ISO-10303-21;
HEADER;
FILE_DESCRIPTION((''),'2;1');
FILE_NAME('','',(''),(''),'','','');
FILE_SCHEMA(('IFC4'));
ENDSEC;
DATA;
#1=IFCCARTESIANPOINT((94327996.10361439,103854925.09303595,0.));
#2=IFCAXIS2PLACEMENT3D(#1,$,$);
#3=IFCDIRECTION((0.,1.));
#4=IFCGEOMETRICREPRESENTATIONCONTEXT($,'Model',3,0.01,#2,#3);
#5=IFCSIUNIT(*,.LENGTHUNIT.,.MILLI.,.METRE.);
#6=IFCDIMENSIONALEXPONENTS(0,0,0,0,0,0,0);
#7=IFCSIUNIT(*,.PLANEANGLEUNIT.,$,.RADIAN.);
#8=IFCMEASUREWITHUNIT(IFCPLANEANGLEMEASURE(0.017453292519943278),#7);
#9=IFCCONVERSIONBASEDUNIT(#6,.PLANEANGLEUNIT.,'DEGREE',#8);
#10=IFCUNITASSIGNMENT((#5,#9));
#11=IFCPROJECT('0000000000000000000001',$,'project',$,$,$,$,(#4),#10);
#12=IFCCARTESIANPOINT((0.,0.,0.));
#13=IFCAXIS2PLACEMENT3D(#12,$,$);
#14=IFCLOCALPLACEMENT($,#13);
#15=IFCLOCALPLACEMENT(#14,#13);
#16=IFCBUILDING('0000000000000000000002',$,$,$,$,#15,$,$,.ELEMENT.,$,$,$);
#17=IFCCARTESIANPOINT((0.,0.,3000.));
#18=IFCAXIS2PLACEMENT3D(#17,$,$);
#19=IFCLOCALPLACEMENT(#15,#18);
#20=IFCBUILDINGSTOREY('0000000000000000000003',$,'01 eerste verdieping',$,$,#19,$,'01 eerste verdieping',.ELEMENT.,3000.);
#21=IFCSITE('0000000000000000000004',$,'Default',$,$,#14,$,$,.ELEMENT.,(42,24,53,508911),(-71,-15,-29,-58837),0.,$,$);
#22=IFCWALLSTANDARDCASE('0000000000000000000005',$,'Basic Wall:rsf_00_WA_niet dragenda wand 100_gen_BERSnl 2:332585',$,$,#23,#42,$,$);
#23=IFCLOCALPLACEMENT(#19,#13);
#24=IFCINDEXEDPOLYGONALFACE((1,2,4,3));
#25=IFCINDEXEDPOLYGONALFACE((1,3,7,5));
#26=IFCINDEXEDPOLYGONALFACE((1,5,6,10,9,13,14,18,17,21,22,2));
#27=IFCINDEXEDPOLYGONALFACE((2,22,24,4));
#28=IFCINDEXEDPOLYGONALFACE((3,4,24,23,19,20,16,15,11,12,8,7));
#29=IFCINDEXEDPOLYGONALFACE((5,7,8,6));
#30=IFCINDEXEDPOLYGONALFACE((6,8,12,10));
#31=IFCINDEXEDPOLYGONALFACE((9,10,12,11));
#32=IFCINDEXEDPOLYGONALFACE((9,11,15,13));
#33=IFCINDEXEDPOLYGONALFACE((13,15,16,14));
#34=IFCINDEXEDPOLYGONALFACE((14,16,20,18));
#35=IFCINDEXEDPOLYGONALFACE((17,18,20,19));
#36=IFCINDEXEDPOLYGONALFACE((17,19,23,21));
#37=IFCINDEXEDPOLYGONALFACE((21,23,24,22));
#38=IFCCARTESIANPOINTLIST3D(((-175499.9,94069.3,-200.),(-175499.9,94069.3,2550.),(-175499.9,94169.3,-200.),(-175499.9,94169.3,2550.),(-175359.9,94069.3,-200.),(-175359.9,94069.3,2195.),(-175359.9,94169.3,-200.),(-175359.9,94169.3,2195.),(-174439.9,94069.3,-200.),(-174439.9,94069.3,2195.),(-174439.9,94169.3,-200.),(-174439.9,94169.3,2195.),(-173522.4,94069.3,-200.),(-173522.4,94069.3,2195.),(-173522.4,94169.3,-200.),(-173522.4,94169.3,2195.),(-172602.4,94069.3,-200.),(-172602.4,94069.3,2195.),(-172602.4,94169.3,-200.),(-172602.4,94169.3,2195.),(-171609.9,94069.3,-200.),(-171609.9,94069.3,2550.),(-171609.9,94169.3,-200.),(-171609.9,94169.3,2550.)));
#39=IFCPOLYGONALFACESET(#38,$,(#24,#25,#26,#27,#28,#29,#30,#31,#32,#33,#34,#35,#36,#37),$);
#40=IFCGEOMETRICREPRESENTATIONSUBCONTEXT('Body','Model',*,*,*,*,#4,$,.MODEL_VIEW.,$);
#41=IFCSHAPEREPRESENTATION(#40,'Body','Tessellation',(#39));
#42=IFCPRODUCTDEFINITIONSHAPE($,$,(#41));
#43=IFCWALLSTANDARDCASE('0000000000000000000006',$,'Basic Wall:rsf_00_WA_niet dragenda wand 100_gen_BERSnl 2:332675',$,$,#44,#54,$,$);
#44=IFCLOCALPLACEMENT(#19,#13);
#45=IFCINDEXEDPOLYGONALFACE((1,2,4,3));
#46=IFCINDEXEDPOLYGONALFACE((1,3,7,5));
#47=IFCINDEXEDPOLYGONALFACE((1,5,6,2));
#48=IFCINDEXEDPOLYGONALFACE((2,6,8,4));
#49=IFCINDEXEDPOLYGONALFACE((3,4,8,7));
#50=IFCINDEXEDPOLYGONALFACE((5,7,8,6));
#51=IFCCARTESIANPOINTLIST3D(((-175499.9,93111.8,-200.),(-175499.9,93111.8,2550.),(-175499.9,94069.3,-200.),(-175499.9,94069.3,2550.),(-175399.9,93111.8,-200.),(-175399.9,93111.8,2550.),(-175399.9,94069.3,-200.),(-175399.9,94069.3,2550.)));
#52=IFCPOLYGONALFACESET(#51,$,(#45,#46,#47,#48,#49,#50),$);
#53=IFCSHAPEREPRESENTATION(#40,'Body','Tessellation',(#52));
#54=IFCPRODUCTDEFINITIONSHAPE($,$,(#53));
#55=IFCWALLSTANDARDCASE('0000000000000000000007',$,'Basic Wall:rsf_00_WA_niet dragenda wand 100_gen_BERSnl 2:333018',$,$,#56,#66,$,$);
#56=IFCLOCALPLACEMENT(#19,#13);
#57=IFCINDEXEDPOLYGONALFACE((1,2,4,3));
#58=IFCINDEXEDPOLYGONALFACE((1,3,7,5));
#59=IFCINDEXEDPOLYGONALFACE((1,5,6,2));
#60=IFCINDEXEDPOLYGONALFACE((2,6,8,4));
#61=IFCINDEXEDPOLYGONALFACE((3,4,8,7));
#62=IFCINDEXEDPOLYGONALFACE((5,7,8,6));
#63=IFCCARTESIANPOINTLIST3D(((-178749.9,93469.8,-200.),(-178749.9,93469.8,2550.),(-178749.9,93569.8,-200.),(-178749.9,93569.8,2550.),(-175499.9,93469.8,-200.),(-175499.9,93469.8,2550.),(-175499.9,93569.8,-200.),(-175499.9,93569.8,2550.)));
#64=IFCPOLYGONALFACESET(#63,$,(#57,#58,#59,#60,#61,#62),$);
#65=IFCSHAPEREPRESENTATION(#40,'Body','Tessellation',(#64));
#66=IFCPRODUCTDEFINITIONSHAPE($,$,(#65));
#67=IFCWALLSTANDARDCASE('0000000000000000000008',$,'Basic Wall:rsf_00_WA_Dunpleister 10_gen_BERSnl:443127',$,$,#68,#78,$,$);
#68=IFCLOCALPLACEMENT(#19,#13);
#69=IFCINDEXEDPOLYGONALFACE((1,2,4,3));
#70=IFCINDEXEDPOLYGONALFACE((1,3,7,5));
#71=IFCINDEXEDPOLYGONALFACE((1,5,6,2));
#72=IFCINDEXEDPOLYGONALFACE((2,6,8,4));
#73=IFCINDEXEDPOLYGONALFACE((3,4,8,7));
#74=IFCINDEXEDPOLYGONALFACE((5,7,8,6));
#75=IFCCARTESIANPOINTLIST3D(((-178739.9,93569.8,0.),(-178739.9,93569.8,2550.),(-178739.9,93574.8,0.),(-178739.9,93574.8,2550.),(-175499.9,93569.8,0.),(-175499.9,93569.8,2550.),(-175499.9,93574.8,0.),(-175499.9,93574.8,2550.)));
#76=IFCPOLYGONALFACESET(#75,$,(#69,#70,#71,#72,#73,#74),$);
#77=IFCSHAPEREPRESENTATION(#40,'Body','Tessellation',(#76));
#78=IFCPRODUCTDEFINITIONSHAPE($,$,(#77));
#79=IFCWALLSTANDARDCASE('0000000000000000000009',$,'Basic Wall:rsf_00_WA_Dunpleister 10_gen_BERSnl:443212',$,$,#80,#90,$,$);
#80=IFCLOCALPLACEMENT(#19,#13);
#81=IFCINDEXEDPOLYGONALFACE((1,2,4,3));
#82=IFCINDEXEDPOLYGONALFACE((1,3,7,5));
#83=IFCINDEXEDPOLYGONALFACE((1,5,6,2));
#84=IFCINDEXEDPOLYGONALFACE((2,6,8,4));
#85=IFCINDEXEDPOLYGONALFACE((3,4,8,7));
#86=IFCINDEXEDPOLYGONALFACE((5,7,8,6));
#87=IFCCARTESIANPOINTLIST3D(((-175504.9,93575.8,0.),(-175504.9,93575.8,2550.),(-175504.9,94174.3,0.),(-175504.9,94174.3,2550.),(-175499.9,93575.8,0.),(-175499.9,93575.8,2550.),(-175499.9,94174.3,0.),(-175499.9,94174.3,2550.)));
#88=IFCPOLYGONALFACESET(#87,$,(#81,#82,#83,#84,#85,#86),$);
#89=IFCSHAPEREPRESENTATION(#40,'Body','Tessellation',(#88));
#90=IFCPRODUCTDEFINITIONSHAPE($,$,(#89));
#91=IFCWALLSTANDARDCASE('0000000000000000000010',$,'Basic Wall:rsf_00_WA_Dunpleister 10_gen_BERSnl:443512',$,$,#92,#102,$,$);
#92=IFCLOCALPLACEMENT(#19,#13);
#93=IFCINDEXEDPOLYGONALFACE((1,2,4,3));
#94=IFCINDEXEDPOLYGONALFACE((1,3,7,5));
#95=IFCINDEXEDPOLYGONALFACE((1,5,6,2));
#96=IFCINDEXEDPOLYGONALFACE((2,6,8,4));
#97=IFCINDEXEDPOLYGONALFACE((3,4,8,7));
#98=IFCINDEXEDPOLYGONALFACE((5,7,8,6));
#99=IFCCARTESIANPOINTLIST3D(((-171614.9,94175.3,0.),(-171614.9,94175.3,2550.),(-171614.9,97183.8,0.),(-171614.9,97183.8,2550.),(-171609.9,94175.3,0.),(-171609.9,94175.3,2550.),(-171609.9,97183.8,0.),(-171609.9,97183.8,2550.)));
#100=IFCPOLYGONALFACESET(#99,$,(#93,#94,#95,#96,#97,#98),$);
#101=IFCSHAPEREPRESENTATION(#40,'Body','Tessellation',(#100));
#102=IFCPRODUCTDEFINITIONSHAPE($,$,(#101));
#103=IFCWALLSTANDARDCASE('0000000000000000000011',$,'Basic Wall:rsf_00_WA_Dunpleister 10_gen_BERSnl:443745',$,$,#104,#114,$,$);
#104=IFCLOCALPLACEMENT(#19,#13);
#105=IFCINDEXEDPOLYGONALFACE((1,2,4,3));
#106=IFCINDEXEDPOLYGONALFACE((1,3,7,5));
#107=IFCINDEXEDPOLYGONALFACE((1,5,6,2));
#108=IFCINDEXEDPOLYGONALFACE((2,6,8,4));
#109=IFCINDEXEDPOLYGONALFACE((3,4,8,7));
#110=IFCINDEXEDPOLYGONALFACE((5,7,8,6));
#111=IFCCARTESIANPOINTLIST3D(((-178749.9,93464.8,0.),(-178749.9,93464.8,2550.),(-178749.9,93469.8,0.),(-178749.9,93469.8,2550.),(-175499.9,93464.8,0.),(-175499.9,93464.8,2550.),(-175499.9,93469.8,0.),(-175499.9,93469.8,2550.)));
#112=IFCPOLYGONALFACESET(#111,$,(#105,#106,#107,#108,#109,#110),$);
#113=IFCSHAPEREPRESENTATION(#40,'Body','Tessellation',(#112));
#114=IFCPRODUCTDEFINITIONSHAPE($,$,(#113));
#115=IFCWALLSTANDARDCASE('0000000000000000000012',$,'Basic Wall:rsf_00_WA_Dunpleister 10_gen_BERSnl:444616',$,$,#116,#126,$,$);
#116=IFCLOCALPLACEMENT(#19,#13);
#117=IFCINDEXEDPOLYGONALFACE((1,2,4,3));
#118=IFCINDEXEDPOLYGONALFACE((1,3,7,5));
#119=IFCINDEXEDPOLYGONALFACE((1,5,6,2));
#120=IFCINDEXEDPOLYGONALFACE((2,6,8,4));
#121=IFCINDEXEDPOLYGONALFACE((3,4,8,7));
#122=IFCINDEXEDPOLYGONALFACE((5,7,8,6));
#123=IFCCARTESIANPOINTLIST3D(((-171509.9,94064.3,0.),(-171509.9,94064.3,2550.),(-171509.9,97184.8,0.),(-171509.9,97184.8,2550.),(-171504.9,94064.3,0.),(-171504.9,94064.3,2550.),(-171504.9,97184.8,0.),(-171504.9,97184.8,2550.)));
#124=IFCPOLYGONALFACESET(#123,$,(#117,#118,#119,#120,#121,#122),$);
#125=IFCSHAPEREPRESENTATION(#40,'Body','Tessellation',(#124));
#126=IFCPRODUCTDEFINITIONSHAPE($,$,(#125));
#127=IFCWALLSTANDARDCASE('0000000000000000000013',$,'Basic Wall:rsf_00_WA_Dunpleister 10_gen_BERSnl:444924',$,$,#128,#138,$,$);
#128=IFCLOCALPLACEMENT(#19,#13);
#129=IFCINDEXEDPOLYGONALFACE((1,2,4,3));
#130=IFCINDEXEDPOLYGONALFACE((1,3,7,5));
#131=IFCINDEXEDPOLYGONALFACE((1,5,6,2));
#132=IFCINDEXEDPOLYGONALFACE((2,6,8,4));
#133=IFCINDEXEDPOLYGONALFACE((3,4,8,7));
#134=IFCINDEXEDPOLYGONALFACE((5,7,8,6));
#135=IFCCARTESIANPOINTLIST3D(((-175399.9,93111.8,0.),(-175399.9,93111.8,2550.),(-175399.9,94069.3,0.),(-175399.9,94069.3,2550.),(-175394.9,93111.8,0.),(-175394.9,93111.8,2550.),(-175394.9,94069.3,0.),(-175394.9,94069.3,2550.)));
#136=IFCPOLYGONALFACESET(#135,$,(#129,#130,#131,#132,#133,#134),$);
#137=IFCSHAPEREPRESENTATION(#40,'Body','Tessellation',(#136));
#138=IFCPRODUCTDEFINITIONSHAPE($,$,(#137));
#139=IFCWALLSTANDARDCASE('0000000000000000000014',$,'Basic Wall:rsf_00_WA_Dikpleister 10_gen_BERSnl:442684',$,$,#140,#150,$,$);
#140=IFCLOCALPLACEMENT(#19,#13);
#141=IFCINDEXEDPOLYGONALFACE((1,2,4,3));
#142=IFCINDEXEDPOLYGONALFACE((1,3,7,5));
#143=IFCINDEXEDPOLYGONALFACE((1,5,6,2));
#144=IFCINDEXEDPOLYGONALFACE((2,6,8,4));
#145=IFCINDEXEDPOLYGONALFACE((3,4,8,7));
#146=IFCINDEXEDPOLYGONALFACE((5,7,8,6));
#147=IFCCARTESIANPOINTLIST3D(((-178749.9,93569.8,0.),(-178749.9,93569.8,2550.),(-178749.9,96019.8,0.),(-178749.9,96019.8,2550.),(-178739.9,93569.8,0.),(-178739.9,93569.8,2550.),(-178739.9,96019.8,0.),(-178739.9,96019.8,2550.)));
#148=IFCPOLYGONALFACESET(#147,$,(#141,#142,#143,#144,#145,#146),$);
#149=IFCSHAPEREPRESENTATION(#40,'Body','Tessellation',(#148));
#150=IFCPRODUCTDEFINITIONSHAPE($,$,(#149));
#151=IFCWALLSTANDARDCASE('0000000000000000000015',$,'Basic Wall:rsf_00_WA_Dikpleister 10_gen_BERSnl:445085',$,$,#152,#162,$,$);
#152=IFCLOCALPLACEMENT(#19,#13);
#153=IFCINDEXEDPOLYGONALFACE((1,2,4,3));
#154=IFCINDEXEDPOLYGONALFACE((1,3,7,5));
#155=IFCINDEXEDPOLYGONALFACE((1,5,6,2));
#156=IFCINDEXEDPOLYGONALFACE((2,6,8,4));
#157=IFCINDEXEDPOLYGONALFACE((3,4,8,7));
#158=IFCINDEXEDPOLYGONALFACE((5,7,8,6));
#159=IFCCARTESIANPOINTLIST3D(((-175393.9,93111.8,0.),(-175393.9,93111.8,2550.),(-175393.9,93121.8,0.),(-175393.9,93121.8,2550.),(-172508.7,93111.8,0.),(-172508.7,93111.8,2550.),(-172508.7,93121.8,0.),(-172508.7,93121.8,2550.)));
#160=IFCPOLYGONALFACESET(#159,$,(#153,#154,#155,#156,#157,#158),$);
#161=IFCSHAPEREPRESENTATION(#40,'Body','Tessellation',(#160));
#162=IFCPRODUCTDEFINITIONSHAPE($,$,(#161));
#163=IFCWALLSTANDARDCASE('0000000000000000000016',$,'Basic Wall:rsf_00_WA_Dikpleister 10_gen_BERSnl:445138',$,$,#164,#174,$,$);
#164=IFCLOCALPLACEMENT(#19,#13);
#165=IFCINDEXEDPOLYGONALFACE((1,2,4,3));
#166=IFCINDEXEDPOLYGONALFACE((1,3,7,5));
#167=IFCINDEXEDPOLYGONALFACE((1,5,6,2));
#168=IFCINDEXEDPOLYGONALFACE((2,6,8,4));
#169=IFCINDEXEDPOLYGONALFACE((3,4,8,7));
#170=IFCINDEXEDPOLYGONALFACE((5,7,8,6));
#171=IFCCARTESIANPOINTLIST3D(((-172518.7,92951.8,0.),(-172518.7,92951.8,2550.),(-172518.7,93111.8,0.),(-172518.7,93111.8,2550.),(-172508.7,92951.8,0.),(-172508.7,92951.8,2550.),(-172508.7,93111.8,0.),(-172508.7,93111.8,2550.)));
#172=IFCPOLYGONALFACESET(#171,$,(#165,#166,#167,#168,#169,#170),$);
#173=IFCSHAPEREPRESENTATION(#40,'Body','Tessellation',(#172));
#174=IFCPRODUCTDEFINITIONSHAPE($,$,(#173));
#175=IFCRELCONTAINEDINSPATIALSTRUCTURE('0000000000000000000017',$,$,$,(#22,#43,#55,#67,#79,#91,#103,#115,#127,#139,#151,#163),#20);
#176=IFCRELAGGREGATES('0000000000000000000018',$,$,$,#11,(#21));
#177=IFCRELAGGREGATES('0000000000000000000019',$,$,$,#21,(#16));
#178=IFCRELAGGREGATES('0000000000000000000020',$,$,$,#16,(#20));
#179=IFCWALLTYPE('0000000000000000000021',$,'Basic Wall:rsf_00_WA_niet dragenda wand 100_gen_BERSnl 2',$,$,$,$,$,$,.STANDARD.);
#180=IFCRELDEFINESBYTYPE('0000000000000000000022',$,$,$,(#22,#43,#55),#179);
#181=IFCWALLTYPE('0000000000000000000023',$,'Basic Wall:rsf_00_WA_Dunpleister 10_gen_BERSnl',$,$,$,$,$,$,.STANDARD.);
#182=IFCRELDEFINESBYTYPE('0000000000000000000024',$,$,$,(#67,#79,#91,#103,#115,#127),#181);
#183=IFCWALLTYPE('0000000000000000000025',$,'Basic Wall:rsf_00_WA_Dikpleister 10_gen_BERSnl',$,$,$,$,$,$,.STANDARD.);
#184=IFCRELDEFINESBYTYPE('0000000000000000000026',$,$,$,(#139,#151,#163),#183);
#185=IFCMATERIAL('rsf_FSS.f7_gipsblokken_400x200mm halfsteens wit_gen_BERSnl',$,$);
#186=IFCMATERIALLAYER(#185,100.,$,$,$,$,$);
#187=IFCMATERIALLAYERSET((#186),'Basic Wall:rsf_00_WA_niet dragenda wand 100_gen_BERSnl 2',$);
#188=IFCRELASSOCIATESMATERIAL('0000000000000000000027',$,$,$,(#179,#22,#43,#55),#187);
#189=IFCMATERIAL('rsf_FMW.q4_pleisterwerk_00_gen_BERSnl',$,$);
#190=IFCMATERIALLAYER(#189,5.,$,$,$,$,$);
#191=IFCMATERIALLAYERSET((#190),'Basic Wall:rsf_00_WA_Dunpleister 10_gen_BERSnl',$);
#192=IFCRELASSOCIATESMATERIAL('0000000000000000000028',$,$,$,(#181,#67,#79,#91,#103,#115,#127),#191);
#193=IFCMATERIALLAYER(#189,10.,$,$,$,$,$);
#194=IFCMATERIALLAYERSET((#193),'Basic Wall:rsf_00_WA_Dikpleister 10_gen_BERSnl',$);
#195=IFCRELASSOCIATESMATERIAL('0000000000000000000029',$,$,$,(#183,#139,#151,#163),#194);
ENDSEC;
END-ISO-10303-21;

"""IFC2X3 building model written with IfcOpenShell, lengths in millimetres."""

from ifc_helpers import new_model, entity, si_unit, converted_unit, direction, frame, frame_2d, origin, place, context, subcontext, project, spatial, rectangle, extrude, material, layer, layer_set, layer_usage, type_object, element, save


model = new_model("IFC2X3")

# Units and contexts
model_context = context("Model", 3, precision=0.01, world=frame((94327996.10361439, 103854925.09303595, 0.0)), true_north=direction((0.0, 1.0)))
body_context = subcontext(model_context, "Body", "Model", "MODEL_VIEW")
ifc_project = project(units=[si_unit("LENGTHUNIT", "METRE", prefix="MILLI"), converted_unit("PLANEANGLEUNIT", "DEGREE", entity("IfcPlaneAngleMeasure", 0.017453292519943278), si_unit("PLANEANGLEUNIT", "RADIAN"), dimensions=[0, 0, 0, 0, 0, 0, 0])], contexts=[model_context])

# Site, building, storey
site_placement = place(None, origin())
site = spatial("IfcSite", under=ifc_project, at=site_placement, Name="Default", CompositionType="ELEMENT", RefLatitude=(42, 24, 53, 508911), RefLongitude=(-71, -15, -29, -58837), RefElevation=0.0)
building_placement = place(site_placement, origin())
building = spatial("IfcBuilding", under=site, at=building_placement, CompositionType="ELEMENT")
storey_placement = place(building_placement, frame((0.0, 0.0, 3000.0)))
storey = spatial("IfcBuildingStorey", under=building, at=storey_placement, Name="01 eerste verdieping", LongName="01 eerste verdieping", CompositionType="ELEMENT", Elevation=3000.0)

# Wall, openings
ifc_material_1 = material(Name="rsf_FSS.f7_gipsblokken_400x200mm halfsteens wit_gen_BERSnl")
ifc_layer_1 = layer(ifc_material_1, 100.0)
ifc_layer_set_1 = layer_set([ifc_layer_1], Name="Basic Wall:rsf_00_WA_niet dragenda wand 100_gen_BERSnl 2")
ifc_layer_usage_1 = layer_usage(ifc_layer_set_1, "AXIS2", "NEGATIVE", 50.0)
wall_type_1 = type_object("IfcWallType", Name="Basic Wall:rsf_00_WA_niet dragenda wand 100_gen_BERSnl 2", PredefinedType="STANDARD", material=ifc_layer_set_1)
wall_1_placement = place(storey_placement, frame((-171609.9, 94119.3, -200.0), z_axis=(0.0, 0.0, 1.0), x_axis=(-1.0, 0.0, 0.0)))
wall_1 = element("IfcWallStandardCase", 1, at=wall_1_placement, inside=storey, type_object=wall_type_1, material=ifc_layer_usage_1, Name="Basic Wall:rsf_00_WA_niet dragenda wand 100_gen_BERSnl 2:332585", context=body_context, shape_type="SweptSolid", body=[
    extrude(rectangle(XDim=3890.0, YDim=100.0, at=frame_2d((1945.0, 0.0), x_axis=(-1.0, 0.0))), origin(), (0.0, 0.0, 1.0), 2750.0),
])
opening_1_placement = place(wall_1_placement, frame((3750.0, 50.0, 0.0)))
element("IfcOpeningElement", 2, at=opening_1_placement, cuts=wall_1, ObjectType="Opening", context=body_context, shape_type="SweptSolid", body=[
    extrude(rectangle(XDim=2395.0, YDim=920.0, at=frame_2d((1197.5, 460.0), x_axis=(-1.0, 0.0))), frame((0.0, 0.0, 0.0), z_axis=(0.0, -1.0, 0.0), x_axis=(0.0, 0.0, 1.0)), (0.0, 0.0, 1.0), 100.0),
])
opening_2_placement = place(wall_1_placement, frame((1912.5, 50.0, 0.0)))
element("IfcOpeningElement", 3, at=opening_2_placement, cuts=wall_1, ObjectType="Opening", context=body_context, shape_type="SweptSolid", body=[
    extrude(rectangle(XDim=2395.0, YDim=920.0, at=frame_2d((1197.5, 460.0), x_axis=(-1.0, 0.0))), frame((0.0, 0.0, 0.0), z_axis=(0.0, -1.0, 0.0), x_axis=(0.0, 0.0, 1.0)), (0.0, 0.0, 1.0), 100.0),
])

# Walls
ifc_layer_usage_2 = layer_usage(ifc_layer_set_1, "AXIS2", "NEGATIVE", 50.0)
wall_2_placement = place(storey_placement, frame((-175449.9, 94069.3, -200.0), z_axis=(0.0, 0.0, 1.0), x_axis=(0.0, -1.0, 0.0)))
element("IfcWallStandardCase", 4, at=wall_2_placement, inside=storey, type_object=wall_type_1, material=ifc_layer_usage_2, Name="Basic Wall:rsf_00_WA_niet dragenda wand 100_gen_BERSnl 2:332675", context=body_context, shape_type="SweptSolid", body=[
    extrude(rectangle(XDim=957.5, YDim=100.0, at=frame_2d((478.7, 0.0), x_axis=(-1.0, 0.0))), origin(), (0.0, 0.0, 1.0), 2750.0),
])
ifc_layer_usage_3 = layer_usage(ifc_layer_set_1, "AXIS2", "POSITIVE", -50.0)
wall_3_placement = place(storey_placement, frame((-175499.9, 93519.8, -200.0), z_axis=(0.0, 0.0, 1.0), x_axis=(-1.0, 0.0, 0.0)))
element("IfcWallStandardCase", 5, at=wall_3_placement, inside=storey, type_object=wall_type_1, material=ifc_layer_usage_3, Name="Basic Wall:rsf_00_WA_niet dragenda wand 100_gen_BERSnl 2:333018", context=body_context, shape_type="SweptSolid", body=[
    extrude(rectangle(XDim=3250.0, YDim=100.0, at=frame_2d((1625.0, 0.0), x_axis=(-1.0, 0.0))), origin(), (0.0, 0.0, 1.0), 2750.0),
])
ifc_material_2 = material(Name="rsf_FMW.q4_pleisterwerk_00_gen_BERSnl")
ifc_layer_2 = layer(ifc_material_2, 5.0)
ifc_layer_set_2 = layer_set([ifc_layer_2], Name="Basic Wall:rsf_00_WA_Dunpleister 10_gen_BERSnl")
ifc_layer_usage_4 = layer_usage(ifc_layer_set_2, "AXIS2", "NEGATIVE", 2.5)
wall_type_2 = type_object("IfcWallType", Name="Basic Wall:rsf_00_WA_Dunpleister 10_gen_BERSnl", PredefinedType="STANDARD", material=ifc_layer_set_2)
wall_4_placement = place(storey_placement, frame((-178739.9, 93572.3, 0.0)))
element("IfcWallStandardCase", 6, at=wall_4_placement, inside=storey, type_object=wall_type_2, material=ifc_layer_usage_4, Name="Basic Wall:rsf_00_WA_Dunpleister 10_gen_BERSnl:443127", context=body_context, shape_type="SweptSolid", body=[
    extrude(rectangle(XDim=3240.0, YDim=5.0, at=frame_2d((1620.0, 0.0), x_axis=(-1.0, 0.0))), origin(), (0.0, 0.0, 1.0), 2550.0),
])
ifc_layer_usage_5 = layer_usage(ifc_layer_set_2, "AXIS2", "NEGATIVE", 2.5)
wall_5_placement = place(storey_placement, frame((-175502.4, 93575.8, 0.0), z_axis=(0.0, 0.0, 1.0), x_axis=(0.0, 1.0, 0.0)))
element("IfcWallStandardCase", 7, at=wall_5_placement, inside=storey, type_object=wall_type_2, material=ifc_layer_usage_5, Name="Basic Wall:rsf_00_WA_Dunpleister 10_gen_BERSnl:443212", context=body_context, shape_type="SweptSolid", body=[
    extrude(rectangle(XDim=598.5, YDim=5.0, at=frame_2d((299.3, 0.0), x_axis=(-1.0, 0.0))), origin(), (0.0, 0.0, 1.0), 2550.0),
])

# Walls
ifc_layer_usage_6 = layer_usage(ifc_layer_set_2, "AXIS2", "NEGATIVE", 2.5)
wall_6_placement = place(storey_placement, frame((-171612.4, 94175.3, 0.0), z_axis=(0.0, 0.0, 1.0), x_axis=(0.0, 1.0, 0.0)))
element("IfcWallStandardCase", 8, at=wall_6_placement, inside=storey, type_object=wall_type_2, material=ifc_layer_usage_6, Name="Basic Wall:rsf_00_WA_Dunpleister 10_gen_BERSnl:443512", context=body_context, shape_type="SweptSolid", body=[
    extrude(rectangle(XDim=3008.5, YDim=5.0, at=frame_2d((1504.2, 0.0), x_axis=(-1.0, 0.0))), origin(), (0.0, 0.0, 1.0), 2550.0),
])
ifc_layer_usage_7 = layer_usage(ifc_layer_set_2, "AXIS2", "NEGATIVE", 2.5)
wall_7_placement = place(storey_placement, frame((-175499.9, 93467.3, 0.0), z_axis=(0.0, 0.0, 1.0), x_axis=(-1.0, 0.0, 0.0)))
element("IfcWallStandardCase", 9, at=wall_7_placement, inside=storey, type_object=wall_type_2, material=ifc_layer_usage_7, Name="Basic Wall:rsf_00_WA_Dunpleister 10_gen_BERSnl:443745", context=body_context, shape_type="SweptSolid", body=[
    extrude(rectangle(XDim=3250.0, YDim=5.0, at=frame_2d((1625.0, 0.0), x_axis=(-1.0, 0.0))), origin(), (0.0, 0.0, 1.0), 2550.0),
])
ifc_layer_usage_8 = layer_usage(ifc_layer_set_2, "AXIS2", "NEGATIVE", 2.5)
wall_8_placement = place(storey_placement, frame((-171507.4, 97184.8, 0.0), z_axis=(0.0, 0.0, 1.0), x_axis=(0.0, -1.0, 0.0)))
element("IfcWallStandardCase", 10, at=wall_8_placement, inside=storey, type_object=wall_type_2, material=ifc_layer_usage_8, Name="Basic Wall:rsf_00_WA_Dunpleister 10_gen_BERSnl:444616", context=body_context, shape_type="SweptSolid", body=[
    extrude(rectangle(XDim=3120.5, YDim=5.0, at=frame_2d((1560.2, 0.0), x_axis=(-1.0, 0.0))), origin(), (0.0, 0.0, 1.0), 2550.0),
])

# Walls
ifc_layer_usage_9 = layer_usage(ifc_layer_set_2, "AXIS2", "NEGATIVE", 2.5)
wall_9_placement = place(storey_placement, frame((-175397.4, 94069.3, 0.0), z_axis=(0.0, 0.0, 1.0), x_axis=(0.0, -1.0, 0.0)))
element("IfcWallStandardCase", 11, at=wall_9_placement, inside=storey, type_object=wall_type_2, material=ifc_layer_usage_9, Name="Basic Wall:rsf_00_WA_Dunpleister 10_gen_BERSnl:444924", context=body_context, shape_type="SweptSolid", body=[
    extrude(rectangle(XDim=957.5, YDim=5.0, at=frame_2d((478.7, 0.0), x_axis=(-1.0, 0.0))), origin(), (0.0, 0.0, 1.0), 2550.0),
])
ifc_layer_3 = layer(ifc_material_2, 10.0)
ifc_layer_set_3 = layer_set([ifc_layer_3], Name="Basic Wall:rsf_00_WA_Dikpleister 10_gen_BERSnl")
ifc_layer_usage_10 = layer_usage(ifc_layer_set_3, "AXIS2", "POSITIVE", -5.0)
wall_type_3 = type_object("IfcWallType", Name="Basic Wall:rsf_00_WA_Dikpleister 10_gen_BERSnl", PredefinedType="STANDARD", material=ifc_layer_set_3)
wall_10_placement = place(storey_placement, frame((-178744.9, 93569.8, 0.0), z_axis=(0.0, 0.0, 1.0), x_axis=(0.0, 1.0, 0.0)))
element("IfcWallStandardCase", 12, at=wall_10_placement, inside=storey, type_object=wall_type_3, material=ifc_layer_usage_10, Name="Basic Wall:rsf_00_WA_Dikpleister 10_gen_BERSnl:442684", context=body_context, shape_type="SweptSolid", body=[
    extrude(rectangle(XDim=2450.0, YDim=10.0, at=frame_2d((1225.0, 0.0), x_axis=(-1.0, 0.0))), origin(), (0.0, 0.0, 1.0), 2550.0),
])
ifc_layer_usage_11 = layer_usage(ifc_layer_set_3, "AXIS2", "NEGATIVE", 5.0)
wall_11_placement = place(storey_placement, frame((-175393.9, 93116.8, 0.0)))
element("IfcWallStandardCase", 13, at=wall_11_placement, inside=storey, type_object=wall_type_3, material=ifc_layer_usage_11, Name="Basic Wall:rsf_00_WA_Dikpleister 10_gen_BERSnl:445085", context=body_context, shape_type="SweptSolid", body=[
    extrude(rectangle(XDim=2885.2, YDim=10.0, at=frame_2d((1442.6, 0.0), x_axis=(-1.0, 0.0))), origin(), (0.0, 0.0, 1.0), 2550.0),
])
ifc_layer_usage_12 = layer_usage(ifc_layer_set_3, "AXIS2", "NEGATIVE", 5.0)
wall_12_placement = place(storey_placement, frame((-172513.7, 93111.8, 0.0), z_axis=(0.0, 0.0, 1.0), x_axis=(0.0, -1.0, 0.0)))
element("IfcWallStandardCase", 14, at=wall_12_placement, inside=storey, type_object=wall_type_3, material=ifc_layer_usage_12, Name="Basic Wall:rsf_00_WA_Dikpleister 10_gen_BERSnl:445138", context=body_context, shape_type="SweptSolid", body=[
    extrude(rectangle(XDim=160.0, YDim=10.0, at=frame_2d((80.0, 0.0), x_axis=(-1.0, 0.0))), origin(), (0.0, 0.0, 1.0), 2550.0),
])

save(model, "model.ifc")
